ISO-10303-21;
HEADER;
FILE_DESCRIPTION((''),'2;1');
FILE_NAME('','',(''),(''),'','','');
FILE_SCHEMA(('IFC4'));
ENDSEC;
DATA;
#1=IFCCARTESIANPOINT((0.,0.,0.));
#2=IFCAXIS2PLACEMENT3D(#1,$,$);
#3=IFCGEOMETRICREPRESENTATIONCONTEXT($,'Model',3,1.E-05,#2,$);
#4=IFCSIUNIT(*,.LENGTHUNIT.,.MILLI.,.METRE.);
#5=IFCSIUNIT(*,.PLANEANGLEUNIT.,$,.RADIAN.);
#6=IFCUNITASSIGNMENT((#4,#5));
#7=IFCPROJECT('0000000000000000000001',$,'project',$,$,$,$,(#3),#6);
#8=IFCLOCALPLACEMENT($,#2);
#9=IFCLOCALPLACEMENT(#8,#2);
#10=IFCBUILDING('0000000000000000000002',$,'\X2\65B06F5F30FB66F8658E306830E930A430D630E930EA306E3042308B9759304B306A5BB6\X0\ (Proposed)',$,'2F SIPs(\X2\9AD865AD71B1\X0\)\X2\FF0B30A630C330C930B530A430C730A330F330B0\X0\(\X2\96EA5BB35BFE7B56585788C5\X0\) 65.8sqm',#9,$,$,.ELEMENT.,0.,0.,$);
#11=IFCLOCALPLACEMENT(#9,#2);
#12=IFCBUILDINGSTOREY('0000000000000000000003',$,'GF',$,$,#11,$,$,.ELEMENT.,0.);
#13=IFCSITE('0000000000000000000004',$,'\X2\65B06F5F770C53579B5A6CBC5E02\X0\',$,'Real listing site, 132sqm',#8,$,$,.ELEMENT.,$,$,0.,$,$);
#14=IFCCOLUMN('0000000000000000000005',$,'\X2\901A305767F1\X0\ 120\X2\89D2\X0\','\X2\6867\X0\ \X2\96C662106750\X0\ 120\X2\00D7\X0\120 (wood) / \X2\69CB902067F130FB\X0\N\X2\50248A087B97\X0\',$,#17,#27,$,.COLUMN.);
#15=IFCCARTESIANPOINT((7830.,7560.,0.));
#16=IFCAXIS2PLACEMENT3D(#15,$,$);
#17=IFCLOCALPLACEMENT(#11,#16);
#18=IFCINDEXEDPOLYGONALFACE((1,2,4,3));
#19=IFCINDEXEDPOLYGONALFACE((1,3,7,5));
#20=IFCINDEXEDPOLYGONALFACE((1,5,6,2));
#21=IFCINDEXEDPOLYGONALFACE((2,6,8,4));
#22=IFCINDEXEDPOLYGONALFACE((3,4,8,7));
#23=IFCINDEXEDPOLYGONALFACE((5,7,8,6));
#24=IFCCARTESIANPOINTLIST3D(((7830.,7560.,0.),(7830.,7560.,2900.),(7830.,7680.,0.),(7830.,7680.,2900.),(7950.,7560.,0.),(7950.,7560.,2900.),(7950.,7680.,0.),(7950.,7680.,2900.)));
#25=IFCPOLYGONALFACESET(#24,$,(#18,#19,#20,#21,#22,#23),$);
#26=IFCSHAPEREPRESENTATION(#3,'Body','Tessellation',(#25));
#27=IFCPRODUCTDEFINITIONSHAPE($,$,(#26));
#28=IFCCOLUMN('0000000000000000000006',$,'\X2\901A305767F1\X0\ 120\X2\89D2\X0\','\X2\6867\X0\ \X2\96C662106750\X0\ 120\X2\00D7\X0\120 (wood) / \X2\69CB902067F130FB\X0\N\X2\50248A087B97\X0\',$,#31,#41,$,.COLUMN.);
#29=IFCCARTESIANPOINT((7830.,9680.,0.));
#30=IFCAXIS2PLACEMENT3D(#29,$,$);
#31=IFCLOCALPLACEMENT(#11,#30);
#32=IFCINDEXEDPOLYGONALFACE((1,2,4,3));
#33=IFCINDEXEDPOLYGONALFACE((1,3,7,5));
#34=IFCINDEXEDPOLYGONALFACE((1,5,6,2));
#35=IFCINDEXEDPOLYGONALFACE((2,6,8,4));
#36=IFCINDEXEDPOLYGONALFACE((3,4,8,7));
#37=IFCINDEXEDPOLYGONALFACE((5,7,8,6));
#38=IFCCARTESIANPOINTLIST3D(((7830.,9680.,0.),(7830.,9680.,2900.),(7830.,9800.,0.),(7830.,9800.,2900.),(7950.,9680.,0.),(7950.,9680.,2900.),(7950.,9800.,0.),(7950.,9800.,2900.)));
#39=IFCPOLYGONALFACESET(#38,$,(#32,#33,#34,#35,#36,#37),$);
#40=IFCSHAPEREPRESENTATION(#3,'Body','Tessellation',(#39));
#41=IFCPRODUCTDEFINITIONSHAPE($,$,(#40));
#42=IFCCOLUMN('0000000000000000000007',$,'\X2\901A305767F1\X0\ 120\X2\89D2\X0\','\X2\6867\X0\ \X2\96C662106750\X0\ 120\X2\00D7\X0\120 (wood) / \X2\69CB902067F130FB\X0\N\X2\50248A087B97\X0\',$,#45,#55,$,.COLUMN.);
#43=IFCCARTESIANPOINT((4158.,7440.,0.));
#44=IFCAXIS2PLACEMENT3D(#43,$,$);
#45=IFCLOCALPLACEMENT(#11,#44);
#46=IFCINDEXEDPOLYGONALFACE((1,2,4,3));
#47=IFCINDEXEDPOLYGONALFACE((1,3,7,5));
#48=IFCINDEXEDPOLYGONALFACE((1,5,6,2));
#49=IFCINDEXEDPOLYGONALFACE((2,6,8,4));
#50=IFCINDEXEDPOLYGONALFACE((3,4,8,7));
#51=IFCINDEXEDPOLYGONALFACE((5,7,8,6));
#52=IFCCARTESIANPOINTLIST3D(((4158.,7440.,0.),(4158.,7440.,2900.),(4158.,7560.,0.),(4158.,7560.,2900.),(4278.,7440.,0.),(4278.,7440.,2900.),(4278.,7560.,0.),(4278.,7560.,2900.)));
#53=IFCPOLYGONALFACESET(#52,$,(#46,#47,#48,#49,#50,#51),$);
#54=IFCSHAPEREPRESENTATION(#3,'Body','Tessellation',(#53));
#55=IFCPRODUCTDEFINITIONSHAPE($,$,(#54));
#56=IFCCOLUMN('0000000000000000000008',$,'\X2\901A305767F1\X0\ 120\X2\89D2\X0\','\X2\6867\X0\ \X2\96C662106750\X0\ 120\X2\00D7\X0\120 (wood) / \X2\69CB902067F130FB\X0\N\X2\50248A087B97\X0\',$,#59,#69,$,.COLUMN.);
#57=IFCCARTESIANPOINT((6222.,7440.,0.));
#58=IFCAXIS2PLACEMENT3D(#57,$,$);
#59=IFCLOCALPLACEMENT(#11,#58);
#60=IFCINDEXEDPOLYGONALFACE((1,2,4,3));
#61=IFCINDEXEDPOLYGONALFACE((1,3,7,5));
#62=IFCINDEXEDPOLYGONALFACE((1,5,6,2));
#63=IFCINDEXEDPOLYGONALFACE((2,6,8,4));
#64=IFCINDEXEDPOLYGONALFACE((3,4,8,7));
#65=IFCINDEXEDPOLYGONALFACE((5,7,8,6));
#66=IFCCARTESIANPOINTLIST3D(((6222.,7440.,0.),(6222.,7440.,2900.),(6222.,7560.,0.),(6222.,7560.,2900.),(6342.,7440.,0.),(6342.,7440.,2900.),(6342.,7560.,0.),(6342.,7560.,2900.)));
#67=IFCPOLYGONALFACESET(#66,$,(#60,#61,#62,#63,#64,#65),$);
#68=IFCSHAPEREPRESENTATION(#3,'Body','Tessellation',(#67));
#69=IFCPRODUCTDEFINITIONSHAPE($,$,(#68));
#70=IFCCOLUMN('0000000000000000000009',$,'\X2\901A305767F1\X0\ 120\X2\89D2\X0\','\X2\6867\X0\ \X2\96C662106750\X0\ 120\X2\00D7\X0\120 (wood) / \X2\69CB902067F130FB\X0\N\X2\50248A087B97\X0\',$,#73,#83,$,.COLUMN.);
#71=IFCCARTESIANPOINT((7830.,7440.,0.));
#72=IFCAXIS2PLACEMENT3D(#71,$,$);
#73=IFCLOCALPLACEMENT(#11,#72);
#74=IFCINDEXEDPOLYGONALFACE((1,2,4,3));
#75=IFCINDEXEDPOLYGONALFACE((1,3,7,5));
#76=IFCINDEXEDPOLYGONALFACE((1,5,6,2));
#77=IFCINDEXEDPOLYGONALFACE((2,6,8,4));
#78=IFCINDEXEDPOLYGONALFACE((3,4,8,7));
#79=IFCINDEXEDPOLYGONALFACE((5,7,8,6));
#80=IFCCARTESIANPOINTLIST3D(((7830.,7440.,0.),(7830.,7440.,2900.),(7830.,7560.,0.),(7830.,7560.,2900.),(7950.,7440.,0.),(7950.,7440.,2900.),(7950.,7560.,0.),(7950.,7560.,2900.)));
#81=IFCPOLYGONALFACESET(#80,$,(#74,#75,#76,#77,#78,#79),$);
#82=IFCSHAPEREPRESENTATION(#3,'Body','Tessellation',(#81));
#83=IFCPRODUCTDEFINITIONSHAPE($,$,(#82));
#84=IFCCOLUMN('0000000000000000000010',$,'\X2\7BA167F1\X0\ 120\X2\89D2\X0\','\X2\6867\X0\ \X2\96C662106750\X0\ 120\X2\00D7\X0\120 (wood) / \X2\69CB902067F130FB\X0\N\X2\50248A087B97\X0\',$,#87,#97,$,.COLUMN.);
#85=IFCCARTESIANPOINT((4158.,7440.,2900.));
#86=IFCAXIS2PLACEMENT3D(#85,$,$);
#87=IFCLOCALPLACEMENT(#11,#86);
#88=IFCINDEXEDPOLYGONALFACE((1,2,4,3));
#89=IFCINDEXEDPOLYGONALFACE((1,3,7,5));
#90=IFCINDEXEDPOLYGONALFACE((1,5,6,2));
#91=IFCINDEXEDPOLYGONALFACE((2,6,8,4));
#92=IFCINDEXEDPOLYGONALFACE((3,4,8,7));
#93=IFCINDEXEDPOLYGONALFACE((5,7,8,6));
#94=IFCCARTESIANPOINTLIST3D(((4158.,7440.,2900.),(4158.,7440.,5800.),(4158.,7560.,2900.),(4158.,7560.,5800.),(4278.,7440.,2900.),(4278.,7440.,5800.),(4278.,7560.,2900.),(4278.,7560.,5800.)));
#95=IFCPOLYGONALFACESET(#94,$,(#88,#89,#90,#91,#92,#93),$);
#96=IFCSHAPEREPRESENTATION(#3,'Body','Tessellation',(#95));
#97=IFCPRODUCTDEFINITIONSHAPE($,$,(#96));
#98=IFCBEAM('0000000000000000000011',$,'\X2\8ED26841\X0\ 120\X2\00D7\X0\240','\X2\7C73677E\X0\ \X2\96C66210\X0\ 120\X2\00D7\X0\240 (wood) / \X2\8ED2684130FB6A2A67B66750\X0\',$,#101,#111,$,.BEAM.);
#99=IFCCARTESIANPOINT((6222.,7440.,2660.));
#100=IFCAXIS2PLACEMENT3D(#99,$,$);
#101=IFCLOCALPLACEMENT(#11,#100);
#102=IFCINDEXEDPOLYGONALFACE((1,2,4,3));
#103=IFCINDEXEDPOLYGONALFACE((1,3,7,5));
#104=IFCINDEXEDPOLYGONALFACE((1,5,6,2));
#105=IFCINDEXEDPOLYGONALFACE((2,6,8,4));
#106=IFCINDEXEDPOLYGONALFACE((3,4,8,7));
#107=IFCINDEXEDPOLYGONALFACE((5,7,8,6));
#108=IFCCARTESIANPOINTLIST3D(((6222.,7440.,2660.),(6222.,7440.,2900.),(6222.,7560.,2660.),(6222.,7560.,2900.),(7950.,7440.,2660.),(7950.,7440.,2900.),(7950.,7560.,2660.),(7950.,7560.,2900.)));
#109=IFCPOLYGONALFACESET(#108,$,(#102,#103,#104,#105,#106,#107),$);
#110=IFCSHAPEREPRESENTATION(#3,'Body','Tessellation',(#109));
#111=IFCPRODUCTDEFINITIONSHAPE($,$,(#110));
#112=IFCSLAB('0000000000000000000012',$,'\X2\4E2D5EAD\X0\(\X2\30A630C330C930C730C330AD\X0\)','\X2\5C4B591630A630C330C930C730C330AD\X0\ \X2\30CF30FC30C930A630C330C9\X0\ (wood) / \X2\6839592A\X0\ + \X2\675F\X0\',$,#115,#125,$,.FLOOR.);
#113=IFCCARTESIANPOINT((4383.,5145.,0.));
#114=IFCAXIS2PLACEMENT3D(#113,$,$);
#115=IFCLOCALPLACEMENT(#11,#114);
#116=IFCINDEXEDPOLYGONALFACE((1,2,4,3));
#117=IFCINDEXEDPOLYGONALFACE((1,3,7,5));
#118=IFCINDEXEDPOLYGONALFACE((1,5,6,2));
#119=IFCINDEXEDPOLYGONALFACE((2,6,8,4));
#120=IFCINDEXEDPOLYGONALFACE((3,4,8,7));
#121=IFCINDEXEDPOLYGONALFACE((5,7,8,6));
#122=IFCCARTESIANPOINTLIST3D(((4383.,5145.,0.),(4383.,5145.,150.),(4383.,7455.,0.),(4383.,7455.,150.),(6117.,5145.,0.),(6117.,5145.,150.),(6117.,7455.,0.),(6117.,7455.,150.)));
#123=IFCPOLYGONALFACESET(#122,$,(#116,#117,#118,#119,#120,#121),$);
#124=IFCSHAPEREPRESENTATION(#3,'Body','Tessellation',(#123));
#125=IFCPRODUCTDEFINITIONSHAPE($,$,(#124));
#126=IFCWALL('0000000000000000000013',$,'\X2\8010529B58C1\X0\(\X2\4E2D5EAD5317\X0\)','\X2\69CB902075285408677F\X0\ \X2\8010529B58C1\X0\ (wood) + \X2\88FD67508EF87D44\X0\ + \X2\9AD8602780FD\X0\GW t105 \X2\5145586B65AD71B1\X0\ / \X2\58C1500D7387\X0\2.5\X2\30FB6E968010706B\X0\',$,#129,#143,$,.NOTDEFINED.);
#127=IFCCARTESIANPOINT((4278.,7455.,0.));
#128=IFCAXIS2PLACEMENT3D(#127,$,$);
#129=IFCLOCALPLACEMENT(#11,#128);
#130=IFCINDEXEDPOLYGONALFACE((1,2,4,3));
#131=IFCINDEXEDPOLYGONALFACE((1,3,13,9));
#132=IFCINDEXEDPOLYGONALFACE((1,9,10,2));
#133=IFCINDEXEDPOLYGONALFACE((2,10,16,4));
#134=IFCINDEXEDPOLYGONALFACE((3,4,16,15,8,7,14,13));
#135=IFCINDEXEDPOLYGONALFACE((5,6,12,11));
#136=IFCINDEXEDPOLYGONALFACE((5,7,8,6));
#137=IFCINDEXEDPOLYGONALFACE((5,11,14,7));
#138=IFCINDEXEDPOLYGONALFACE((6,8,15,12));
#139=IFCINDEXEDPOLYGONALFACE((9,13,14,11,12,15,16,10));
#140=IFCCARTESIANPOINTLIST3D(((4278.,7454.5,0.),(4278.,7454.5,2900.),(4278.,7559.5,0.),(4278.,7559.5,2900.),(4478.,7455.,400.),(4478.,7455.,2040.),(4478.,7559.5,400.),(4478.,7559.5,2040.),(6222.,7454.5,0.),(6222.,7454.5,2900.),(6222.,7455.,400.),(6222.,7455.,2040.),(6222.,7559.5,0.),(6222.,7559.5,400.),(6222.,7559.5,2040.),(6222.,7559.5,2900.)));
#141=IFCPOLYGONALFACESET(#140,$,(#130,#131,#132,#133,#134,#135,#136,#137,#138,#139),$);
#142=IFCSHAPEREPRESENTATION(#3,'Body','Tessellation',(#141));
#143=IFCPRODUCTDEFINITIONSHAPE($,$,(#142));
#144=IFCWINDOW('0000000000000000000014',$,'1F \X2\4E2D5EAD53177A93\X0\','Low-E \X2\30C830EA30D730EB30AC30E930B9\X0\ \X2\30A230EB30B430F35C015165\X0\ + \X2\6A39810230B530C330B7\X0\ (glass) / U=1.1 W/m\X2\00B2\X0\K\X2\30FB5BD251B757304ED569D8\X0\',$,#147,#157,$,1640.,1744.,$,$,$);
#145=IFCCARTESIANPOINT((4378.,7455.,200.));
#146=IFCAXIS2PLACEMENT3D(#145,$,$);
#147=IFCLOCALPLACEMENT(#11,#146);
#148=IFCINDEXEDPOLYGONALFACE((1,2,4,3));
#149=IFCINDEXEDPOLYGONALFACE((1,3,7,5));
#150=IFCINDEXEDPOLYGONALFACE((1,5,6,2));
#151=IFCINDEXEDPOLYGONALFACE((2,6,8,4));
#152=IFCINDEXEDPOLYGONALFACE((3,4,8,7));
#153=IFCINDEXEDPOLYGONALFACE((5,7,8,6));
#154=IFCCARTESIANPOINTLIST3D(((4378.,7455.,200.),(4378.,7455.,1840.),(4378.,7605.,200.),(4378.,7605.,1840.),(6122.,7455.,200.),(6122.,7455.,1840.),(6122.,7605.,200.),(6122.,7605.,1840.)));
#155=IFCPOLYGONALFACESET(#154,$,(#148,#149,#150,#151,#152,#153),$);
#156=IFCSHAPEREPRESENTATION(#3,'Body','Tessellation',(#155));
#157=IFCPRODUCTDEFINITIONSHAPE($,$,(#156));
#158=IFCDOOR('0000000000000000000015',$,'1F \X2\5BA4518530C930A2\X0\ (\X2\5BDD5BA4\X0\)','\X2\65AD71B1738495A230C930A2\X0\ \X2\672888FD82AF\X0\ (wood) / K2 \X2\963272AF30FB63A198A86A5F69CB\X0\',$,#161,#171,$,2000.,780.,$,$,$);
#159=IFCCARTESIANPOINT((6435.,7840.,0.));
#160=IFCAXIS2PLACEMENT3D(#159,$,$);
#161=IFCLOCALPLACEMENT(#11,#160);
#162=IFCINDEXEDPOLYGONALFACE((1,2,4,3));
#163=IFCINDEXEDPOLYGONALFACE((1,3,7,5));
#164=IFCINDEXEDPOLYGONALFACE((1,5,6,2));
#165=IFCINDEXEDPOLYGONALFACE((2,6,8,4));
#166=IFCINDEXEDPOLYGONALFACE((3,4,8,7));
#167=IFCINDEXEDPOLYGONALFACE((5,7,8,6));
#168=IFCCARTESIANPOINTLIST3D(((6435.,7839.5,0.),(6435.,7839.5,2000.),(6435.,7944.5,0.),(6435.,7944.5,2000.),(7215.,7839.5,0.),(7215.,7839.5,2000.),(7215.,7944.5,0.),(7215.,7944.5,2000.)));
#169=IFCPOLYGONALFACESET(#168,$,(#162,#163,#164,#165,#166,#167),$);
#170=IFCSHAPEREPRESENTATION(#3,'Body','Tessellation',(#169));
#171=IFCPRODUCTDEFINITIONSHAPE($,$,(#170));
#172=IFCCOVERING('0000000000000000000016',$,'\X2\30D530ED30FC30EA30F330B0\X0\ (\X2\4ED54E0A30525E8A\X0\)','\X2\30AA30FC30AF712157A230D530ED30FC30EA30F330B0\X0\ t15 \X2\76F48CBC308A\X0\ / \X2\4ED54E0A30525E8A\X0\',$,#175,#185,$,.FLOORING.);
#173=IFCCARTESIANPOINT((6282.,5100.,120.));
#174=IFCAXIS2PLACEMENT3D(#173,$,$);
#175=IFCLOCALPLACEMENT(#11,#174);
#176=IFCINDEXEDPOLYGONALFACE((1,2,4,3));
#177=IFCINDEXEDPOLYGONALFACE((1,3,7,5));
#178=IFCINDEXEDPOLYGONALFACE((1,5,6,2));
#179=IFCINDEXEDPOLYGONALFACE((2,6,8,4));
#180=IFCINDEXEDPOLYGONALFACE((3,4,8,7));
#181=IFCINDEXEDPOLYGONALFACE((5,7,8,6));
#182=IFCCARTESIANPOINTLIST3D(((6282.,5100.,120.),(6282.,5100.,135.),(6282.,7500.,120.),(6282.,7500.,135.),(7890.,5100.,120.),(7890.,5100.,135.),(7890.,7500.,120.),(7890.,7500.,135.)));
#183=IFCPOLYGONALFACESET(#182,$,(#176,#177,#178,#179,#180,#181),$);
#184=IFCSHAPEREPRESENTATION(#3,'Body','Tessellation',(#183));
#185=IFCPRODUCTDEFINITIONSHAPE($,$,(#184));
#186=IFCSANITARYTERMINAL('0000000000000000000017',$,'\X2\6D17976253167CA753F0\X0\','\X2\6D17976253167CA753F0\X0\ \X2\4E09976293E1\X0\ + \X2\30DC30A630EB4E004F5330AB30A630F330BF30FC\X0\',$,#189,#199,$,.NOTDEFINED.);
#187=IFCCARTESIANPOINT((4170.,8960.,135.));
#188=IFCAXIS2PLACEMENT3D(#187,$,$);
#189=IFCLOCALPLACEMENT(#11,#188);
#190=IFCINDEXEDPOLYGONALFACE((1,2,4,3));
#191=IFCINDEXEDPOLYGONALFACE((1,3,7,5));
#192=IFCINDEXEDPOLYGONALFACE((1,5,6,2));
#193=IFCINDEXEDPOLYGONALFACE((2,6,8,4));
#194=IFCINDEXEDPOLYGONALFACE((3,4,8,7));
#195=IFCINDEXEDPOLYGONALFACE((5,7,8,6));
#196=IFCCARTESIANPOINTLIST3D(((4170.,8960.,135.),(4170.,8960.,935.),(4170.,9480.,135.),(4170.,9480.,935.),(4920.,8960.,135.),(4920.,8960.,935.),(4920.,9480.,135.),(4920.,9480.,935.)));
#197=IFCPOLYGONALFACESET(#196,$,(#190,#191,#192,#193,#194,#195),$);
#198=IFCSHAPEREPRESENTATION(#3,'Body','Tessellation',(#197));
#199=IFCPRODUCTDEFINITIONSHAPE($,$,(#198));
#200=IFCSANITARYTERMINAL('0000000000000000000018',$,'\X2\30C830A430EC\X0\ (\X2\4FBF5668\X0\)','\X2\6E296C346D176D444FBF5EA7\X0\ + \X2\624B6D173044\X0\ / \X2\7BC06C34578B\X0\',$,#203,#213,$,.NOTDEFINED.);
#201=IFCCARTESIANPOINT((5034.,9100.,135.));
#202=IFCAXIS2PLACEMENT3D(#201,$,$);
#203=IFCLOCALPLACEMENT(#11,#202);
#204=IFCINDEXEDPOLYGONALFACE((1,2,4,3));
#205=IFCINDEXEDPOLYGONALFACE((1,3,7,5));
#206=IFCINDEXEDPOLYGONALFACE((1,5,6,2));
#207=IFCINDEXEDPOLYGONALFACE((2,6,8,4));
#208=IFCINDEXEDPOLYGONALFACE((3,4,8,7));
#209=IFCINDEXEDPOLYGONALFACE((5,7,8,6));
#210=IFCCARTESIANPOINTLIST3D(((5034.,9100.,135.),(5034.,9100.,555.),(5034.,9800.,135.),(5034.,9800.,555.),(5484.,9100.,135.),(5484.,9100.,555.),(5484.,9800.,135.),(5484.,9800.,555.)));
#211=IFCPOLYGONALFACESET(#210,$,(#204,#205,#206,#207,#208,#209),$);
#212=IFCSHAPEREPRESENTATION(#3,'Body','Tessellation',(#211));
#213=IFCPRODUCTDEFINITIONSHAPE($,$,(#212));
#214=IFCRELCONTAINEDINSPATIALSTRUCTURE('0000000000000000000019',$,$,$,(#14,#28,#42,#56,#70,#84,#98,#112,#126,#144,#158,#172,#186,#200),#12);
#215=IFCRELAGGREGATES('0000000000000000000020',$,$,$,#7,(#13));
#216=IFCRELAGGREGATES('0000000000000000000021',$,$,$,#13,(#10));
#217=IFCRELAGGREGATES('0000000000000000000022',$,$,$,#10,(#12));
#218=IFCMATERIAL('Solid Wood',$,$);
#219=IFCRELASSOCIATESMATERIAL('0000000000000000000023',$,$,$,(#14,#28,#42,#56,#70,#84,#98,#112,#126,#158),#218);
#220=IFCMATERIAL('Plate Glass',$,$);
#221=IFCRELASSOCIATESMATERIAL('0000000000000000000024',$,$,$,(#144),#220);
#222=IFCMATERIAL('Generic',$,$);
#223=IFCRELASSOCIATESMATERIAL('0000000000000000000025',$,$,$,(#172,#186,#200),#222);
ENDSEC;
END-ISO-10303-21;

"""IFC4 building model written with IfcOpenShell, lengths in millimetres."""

from ifc_helpers import new_model, si_unit, frame, frame_2d, origin, place, context, project, spatial, rectangle, extrude, material, element, fill, save


model = new_model("IFC4")

# Units and contexts
model_context = context("Model", 3, precision=1e-05, world=origin())
ifc_project = project(units=[si_unit("LENGTHUNIT", "METRE", prefix="MILLI"), si_unit("PLANEANGLEUNIT", "RADIAN")], contexts=[model_context])

# Site, building, storey
site_placement = place(None, origin())
site = spatial("IfcSite", under=ifc_project, at=site_placement, Name="新潟県南魚沼市", ObjectType="Real listing site, 132sqm", CompositionType="ELEMENT", RefElevation=0.0)
building_placement = place(site_placement, origin())
building = spatial("IfcBuilding", under=site, at=building_placement, Name="新潟・書斎とライブラリのある静かな家 (Proposed)", ObjectType="2F SIPs(高断熱)＋ウッドサイディング(雪害対策塗装) 65.8sqm", CompositionType="ELEMENT", ElevationOfRefHeight=0.0, ElevationOfTerrain=0.0)
storey_placement = place(building_placement, origin())
storey = spatial("IfcBuildingStorey", under=building, at=storey_placement, Name="GF", CompositionType="ELEMENT", Elevation=0.0)

# Columns
ifc_material_1 = material(Name="Solid Wood")
column_1_placement = place(storey_placement, frame((7830.0, 7560.0, 0.0)))
element("IfcColumn", 1, at=column_1_placement, inside=storey, material=ifc_material_1, Name="通し柱 120角", Description="桧 集成材 120×120 (wood) / 構造柱・N値計算", PredefinedType="COLUMN", context=model_context, shape_type="SweptSolid", body=[
    extrude(rectangle(XDim=120.0, YDim=120.0, at=frame_2d((60.0, 60.0))), frame((7830.0, 7560.0, 0.0)), (0.0, 0.0, 1.0), 2900.0),
])
column_2_placement = place(storey_placement, frame((7830.0, 9680.0, 0.0)))
element("IfcColumn", 2, at=column_2_placement, inside=storey, material=ifc_material_1, Name="通し柱 120角", Description="桧 集成材 120×120 (wood) / 構造柱・N値計算", PredefinedType="COLUMN", context=model_context, shape_type="SweptSolid", body=[
    extrude(rectangle(XDim=120.0, YDim=120.0, at=frame_2d((60.0, 60.0))), frame((7830.0, 9680.0, 0.0)), (0.0, 0.0, 1.0), 2900.0),
])
column_3_placement = place(storey_placement, frame((4158.0, 7440.0, 0.0)))
element("IfcColumn", 3, at=column_3_placement, inside=storey, material=ifc_material_1, Name="通し柱 120角", Description="桧 集成材 120×120 (wood) / 構造柱・N値計算", PredefinedType="COLUMN", context=model_context, shape_type="SweptSolid", body=[
    extrude(rectangle(XDim=120.0, YDim=120.0, at=frame_2d((60.0, 60.0))), frame((4158.0, 7440.0, 0.0)), (0.0, 0.0, 1.0), 2900.0),
])
column_4_placement = place(storey_placement, frame((6222.0, 7440.0, 0.0)))
element("IfcColumn", 4, at=column_4_placement, inside=storey, material=ifc_material_1, Name="通し柱 120角", Description="桧 集成材 120×120 (wood) / 構造柱・N値計算", PredefinedType="COLUMN", context=model_context, shape_type="SweptSolid", body=[
    extrude(rectangle(XDim=120.0, YDim=120.0, at=frame_2d((60.0, 60.0))), frame((6222.0, 7440.0, 0.0)), (0.0, 0.0, 1.0), 2900.0),
])
column_5_placement = place(storey_placement, frame((7830.0, 7440.0, 0.0)))
element("IfcColumn", 5, at=column_5_placement, inside=storey, material=ifc_material_1, Name="通し柱 120角", Description="桧 集成材 120×120 (wood) / 構造柱・N値計算", PredefinedType="COLUMN", context=model_context, shape_type="SweptSolid", body=[
    extrude(rectangle(XDim=120.0, YDim=120.0, at=frame_2d((60.0, 60.0))), frame((7830.0, 7440.0, 0.0)), (0.0, 0.0, 1.0), 2900.0),
])
column_6_placement = place(storey_placement, frame((4158.0, 7440.0, 2900.0)))
element("IfcColumn", 6, at=column_6_placement, inside=storey, material=ifc_material_1, Name="管柱 120角", Description="桧 集成材 120×120 (wood) / 構造柱・N値計算", PredefinedType="COLUMN", context=model_context, shape_type="SweptSolid", body=[
    extrude(rectangle(XDim=120.0, YDim=120.0, at=frame_2d((60.0, 60.0))), frame((4158.0, 7440.0, 2900.0)), (0.0, 0.0, 1.0), 2900.0),
])

# Beam
beam_1_placement = place(storey_placement, frame((6222.0, 7440.0, 2660.0)))
element("IfcBeam", 7, at=beam_1_placement, inside=storey, material=ifc_material_1, Name="軒桁 120×240", Description="米松 集成 120×240 (wood) / 軒桁・横架材", PredefinedType="BEAM", context=model_context, shape_type="SweptSolid", body=[
    extrude(rectangle(XDim=1728.0, YDim=120.0, at=frame_2d((864.0, 60.0))), frame((6222.0, 7440.0, 2660.0)), (0.0, 0.0, 1.0), 240.0),
])

# Slab
slab_placement = place(storey_placement, frame((4383.0, 5145.0, 0.0)))
element("IfcSlab", 8, at=slab_placement, inside=storey, material=ifc_material_1, Name="中庭(ウッドデッキ)", Description="屋外ウッドデッキ ハードウッド (wood) / 根太 + 束", PredefinedType="FLOOR", context=model_context, shape_type="SweptSolid", body=[
    extrude(rectangle(XDim=1734.0, YDim=2310.0, at=frame_2d((867.0, 1155.0))), frame((4383.0, 5145.0, 0.0)), (0.0, 0.0, 1.0), 150.0),
])

# Wall, opening, window
wall_1_placement = place(storey_placement, frame((4278.0, 7455.0, 0.0)))
wall_1 = element("IfcWall", 9, at=wall_1_placement, inside=storey, material=ifc_material_1, Name="耐力壁(中庭北)", Description="構造用合板 耐力壁 (wood) + 製材軸組 + 高性能GW t105 充填断熱 / 壁倍率2.5・準耐火", PredefinedType="NOTDEFINED", context=model_context, shape_type="SweptSolid", body=[
    extrude(rectangle(XDim=1944.0, YDim=105.0, at=frame_2d((972.0, 52.0))), frame((4278.0, 7455.0, 0.0)), (0.0, 0.0, 1.0), 2900.0),
])
opening_placement = place(storey_placement, frame((4378.0, 7455.0, 200.0)))
opening = element("IfcOpeningElement", 10, at=opening_placement, cuts=wall_1, PredefinedType="NOTDEFINED", context=model_context, shape_type="SweptSolid", body=[
    extrude(rectangle(XDim=1744.0, YDim=150.0, at=frame_2d((872.0, 75.0))), frame((4378.0, 7455.0, 200.0)), (0.0, 0.0, 1.0), 1640.0),
])
ifc_material_2 = material(Name="Plate Glass")
window_placement = place(storey_placement, frame((4378.0, 7455.0, 200.0)))
window = element("IfcWindow", 11, at=window_placement, inside=storey, material=ifc_material_2, Name="1F 中庭北窓", Description="Low-E トリプルガラス アルゴン封入 + 樹脂サッシ (glass) / U=1.1 W/m²K・寒冷地仕様", OverallHeight=1640.0, OverallWidth=1744.0, context=model_context, shape_type="SweptSolid", body=[
    extrude(rectangle(XDim=1744.0, YDim=150.0, at=frame_2d((872.0, 75.0))), frame((4378.0, 7455.0, 200.0)), (0.0, 0.0, 1.0), 1640.0),
])
fill(opening, window)

# Door
door_placement = place(storey_placement, frame((6435.0, 7840.0, 0.0)))
element("IfcDoor", 12, at=door_placement, inside=storey, material=ifc_material_1, Name="1F 室内ドア (寝室)", Description="断熱玄関ドア 木製芯 (wood) / K2 防犯・採風機構", OverallHeight=2000.0, OverallWidth=780.0, context=model_context, shape_type="SweptSolid", body=[
    extrude(rectangle(XDim=780.0, YDim=105.0, at=frame_2d((390.0, 52.0))), frame((6435.0, 7840.0, 0.0)), (0.0, 0.0, 1.0), 2000.0),
])

# Covering
ifc_material_3 = material(Name="Generic")
covering_placement = place(storey_placement, frame((6282.0, 5100.0, 120.0)))
element("IfcCovering", 13, at=covering_placement, inside=storey, material=ifc_material_3, Name="フローリング (仕上げ床)", Description="オーク無垢フローリング t15 直貼り / 仕上げ床", PredefinedType="FLOORING", context=model_context, shape_type="SweptSolid", body=[
    extrude(rectangle(XDim=1608.0, YDim=2400.0, at=frame_2d((804.0, 1200.0))), frame((6282.0, 5100.0, 120.0)), (0.0, 0.0, 1.0), 15.0),
])

# Sanitary terminals
sanitary_terminal_1_placement = place(storey_placement, frame((4170.0, 8960.0, 135.0)))
element("IfcSanitaryTerminal", 14, at=sanitary_terminal_1_placement, inside=storey, material=ifc_material_3, Name="洗面化粧台", Description="洗面化粧台 三面鏡 + ボウル一体カウンター", PredefinedType="NOTDEFINED", context=model_context, shape_type="SweptSolid", body=[
    extrude(rectangle(XDim=750.0, YDim=520.0, at=frame_2d((375.0, 260.0))), frame((4170.0, 8960.0, 135.0)), (0.0, 0.0, 1.0), 800.0),
])
sanitary_terminal_2_placement = place(storey_placement, frame((5034.0, 9100.0, 135.0)))
element("IfcSanitaryTerminal", 15, at=sanitary_terminal_2_placement, inside=storey, material=ifc_material_3, Name="トイレ (便器)", Description="温水洗浄便座 + 手洗い / 節水型", PredefinedType="NOTDEFINED", context=model_context, shape_type="SweptSolid", body=[
    extrude(rectangle(XDim=450.0, YDim=700.0, at=frame_2d((225.0, 350.0))), frame((5034.0, 9100.0, 135.0)), (0.0, 0.0, 1.0), 420.0),
])

save(model, "model.ifc")
